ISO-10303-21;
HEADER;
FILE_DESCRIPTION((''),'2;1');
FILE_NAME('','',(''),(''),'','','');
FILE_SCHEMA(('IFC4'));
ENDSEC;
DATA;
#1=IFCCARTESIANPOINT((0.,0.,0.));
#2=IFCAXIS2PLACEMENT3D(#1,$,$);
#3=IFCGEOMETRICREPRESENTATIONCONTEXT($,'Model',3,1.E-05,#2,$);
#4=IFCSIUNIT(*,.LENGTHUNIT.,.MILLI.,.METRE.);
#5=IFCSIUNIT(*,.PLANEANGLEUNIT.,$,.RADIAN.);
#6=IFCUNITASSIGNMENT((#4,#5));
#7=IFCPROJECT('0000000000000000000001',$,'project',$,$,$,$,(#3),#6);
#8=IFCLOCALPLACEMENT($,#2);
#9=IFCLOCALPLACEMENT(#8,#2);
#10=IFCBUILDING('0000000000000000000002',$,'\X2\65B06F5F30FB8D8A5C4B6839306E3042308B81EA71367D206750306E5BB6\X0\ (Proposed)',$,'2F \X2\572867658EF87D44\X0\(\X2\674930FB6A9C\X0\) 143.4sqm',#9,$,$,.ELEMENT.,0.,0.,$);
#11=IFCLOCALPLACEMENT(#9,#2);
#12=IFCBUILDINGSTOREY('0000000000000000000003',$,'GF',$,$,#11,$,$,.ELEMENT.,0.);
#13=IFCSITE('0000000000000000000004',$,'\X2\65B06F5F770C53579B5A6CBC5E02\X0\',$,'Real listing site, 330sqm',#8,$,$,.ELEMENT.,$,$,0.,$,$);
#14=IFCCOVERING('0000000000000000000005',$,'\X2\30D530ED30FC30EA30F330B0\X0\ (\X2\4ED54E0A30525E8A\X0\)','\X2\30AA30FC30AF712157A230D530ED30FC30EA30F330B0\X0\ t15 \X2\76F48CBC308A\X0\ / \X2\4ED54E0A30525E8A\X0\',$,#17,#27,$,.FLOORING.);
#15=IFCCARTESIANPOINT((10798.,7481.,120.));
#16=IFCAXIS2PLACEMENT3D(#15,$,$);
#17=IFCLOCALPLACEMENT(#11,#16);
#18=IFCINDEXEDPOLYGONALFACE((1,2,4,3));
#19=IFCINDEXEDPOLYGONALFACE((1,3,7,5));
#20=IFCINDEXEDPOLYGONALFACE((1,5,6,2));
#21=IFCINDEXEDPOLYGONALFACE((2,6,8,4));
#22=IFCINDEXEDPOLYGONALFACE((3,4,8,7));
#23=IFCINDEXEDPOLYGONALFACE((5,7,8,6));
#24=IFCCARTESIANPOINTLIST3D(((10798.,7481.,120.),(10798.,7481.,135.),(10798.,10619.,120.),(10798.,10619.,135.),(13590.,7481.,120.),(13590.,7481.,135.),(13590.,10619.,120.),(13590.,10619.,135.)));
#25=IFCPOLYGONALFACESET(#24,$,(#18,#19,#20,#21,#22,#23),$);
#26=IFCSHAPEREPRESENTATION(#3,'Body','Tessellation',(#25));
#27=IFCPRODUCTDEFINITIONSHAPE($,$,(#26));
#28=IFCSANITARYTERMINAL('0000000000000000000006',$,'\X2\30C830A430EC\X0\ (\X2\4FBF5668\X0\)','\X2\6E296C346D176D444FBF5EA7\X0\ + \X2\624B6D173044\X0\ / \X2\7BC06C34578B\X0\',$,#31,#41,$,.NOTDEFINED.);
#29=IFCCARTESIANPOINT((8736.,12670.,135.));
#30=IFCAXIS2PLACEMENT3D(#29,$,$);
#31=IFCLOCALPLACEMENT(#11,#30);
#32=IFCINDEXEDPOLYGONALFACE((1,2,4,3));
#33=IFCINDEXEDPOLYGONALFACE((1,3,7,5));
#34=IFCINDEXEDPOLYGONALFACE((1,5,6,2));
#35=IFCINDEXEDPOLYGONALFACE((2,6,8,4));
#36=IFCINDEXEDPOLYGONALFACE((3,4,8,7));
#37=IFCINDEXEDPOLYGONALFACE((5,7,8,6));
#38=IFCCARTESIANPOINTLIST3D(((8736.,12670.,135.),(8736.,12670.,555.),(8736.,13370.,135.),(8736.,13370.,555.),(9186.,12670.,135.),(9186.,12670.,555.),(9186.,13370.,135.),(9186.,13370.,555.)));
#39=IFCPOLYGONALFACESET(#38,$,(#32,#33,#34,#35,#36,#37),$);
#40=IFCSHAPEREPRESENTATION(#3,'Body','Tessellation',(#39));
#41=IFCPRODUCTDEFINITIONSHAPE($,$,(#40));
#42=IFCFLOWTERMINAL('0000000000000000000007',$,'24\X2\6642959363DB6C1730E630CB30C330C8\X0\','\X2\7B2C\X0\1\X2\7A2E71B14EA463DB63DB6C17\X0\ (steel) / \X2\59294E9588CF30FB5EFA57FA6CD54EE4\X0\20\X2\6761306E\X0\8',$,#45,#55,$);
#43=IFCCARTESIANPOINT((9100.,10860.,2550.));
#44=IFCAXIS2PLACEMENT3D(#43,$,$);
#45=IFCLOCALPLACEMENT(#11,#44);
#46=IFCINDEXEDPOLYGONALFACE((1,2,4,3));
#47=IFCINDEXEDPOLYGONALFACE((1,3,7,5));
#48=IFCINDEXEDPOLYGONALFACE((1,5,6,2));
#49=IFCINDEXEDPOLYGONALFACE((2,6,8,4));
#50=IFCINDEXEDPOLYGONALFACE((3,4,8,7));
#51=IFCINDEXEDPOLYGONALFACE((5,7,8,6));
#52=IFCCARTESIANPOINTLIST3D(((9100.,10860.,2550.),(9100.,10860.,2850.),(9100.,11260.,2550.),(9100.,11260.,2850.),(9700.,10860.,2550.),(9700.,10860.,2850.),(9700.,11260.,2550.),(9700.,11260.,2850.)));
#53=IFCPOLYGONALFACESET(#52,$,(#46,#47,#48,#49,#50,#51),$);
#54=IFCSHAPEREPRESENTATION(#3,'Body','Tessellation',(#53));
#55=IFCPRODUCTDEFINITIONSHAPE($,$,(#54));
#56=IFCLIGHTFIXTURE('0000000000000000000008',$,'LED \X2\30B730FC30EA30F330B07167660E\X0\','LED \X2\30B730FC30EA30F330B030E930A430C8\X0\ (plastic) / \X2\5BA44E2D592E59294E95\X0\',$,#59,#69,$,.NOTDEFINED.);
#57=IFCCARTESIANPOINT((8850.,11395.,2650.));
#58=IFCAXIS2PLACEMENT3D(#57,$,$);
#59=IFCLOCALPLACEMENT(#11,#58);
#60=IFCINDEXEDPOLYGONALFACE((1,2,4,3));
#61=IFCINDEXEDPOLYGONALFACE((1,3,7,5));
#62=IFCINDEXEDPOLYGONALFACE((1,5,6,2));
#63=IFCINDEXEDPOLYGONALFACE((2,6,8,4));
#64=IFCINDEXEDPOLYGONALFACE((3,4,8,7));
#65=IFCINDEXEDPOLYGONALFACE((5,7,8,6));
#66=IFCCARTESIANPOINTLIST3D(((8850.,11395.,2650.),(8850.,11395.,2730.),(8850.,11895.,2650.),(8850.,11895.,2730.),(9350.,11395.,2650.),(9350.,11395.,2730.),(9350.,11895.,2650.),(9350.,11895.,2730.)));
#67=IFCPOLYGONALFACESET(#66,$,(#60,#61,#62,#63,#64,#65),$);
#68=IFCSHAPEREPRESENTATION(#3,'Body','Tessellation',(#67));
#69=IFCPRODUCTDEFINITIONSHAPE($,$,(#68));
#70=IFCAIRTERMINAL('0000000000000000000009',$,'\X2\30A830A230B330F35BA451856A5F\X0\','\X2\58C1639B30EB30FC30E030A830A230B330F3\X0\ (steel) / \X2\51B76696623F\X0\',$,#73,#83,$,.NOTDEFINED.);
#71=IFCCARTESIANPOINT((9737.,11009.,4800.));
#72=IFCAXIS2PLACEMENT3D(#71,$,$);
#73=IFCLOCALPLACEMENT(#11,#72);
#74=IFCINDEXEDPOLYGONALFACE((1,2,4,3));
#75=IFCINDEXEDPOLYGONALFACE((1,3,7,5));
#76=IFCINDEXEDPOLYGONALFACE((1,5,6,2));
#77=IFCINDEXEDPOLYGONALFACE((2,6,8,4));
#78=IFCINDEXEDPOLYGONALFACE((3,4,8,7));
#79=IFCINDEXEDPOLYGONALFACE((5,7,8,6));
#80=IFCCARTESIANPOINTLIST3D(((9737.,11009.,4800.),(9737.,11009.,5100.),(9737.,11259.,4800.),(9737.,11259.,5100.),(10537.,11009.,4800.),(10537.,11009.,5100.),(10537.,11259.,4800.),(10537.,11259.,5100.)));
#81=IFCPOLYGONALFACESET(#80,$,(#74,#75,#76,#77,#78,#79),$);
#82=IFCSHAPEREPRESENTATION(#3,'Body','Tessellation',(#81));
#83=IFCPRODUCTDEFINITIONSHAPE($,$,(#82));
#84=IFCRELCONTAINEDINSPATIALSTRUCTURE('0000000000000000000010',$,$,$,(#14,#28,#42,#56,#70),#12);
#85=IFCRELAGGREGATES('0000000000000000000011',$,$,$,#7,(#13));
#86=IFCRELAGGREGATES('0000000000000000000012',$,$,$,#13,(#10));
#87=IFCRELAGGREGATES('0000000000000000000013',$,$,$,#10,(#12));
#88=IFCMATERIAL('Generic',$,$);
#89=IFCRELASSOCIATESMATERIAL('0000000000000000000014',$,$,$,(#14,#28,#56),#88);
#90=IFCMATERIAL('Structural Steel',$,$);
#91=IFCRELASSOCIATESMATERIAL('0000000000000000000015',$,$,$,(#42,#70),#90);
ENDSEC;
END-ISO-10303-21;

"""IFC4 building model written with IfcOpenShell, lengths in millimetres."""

from ifc_helpers import new_model, si_unit, frame, frame_2d, origin, place, context, project, spatial, rectangle, extrude, material, element, save


model = new_model("IFC4")

# Units and contexts
model_context = context("Model", 3, precision=1e-05, world=origin())
ifc_project = project(units=[si_unit("LENGTHUNIT", "METRE", prefix="MILLI"), si_unit("PLANEANGLEUNIT", "RADIAN")], contexts=[model_context])

# Site, building, storey
site_placement = place(None, origin())
site = spatial("IfcSite", under=ifc_project, at=site_placement, Name="新潟県南魚沼市", ObjectType="Real listing site, 330sqm", CompositionType="ELEMENT", RefElevation=0.0)
building_placement = place(site_placement, origin())
building = spatial("IfcBuilding", under=site, at=building_placement, Name="新潟・越屋根のある自然素材の家 (Proposed)", ObjectType="2F 在来軸組(杉・檜) 143.4sqm", CompositionType="ELEMENT", ElevationOfRefHeight=0.0, ElevationOfTerrain=0.0)
storey_placement = place(building_placement, origin())
storey = spatial("IfcBuildingStorey", under=building, at=storey_placement, Name="GF", CompositionType="ELEMENT", Elevation=0.0)

# Covering
ifc_material_1 = material(Name="Generic")
covering_placement = place(storey_placement, frame((10798.0, 7481.0, 120.0)))
element("IfcCovering", 1, at=covering_placement, inside=storey, material=ifc_material_1, Name="フローリング (仕上げ床)", Description="オーク無垢フローリング t15 直貼り / 仕上げ床", PredefinedType="FLOORING", context=model_context, shape_type="SweptSolid", body=[
    extrude(rectangle(XDim=2792.0, YDim=3138.0, at=frame_2d((1396.0, 1569.0))), frame((10798.0, 7481.0, 120.0)), (0.0, 0.0, 1.0), 15.0),
])

# Sanitary terminal
sanitary_terminal_placement = place(storey_placement, frame((8736.0, 12670.0, 135.0)))
element("IfcSanitaryTerminal", 2, at=sanitary_terminal_placement, inside=storey, material=ifc_material_1, Name="トイレ (便器)", Description="温水洗浄便座 + 手洗い / 節水型", PredefinedType="NOTDEFINED", context=model_context, shape_type="SweptSolid", body=[
    extrude(rectangle(XDim=450.0, YDim=700.0, at=frame_2d((225.0, 350.0))), frame((8736.0, 12670.0, 135.0)), (0.0, 0.0, 1.0), 420.0),
])

# Flow terminal
ifc_material_2 = material(Name="Structural Steel")
flow_terminal_placement = place(storey_placement, frame((9100.0, 10860.0, 2550.0)))
element("IfcFlowTerminal", 3, at=flow_terminal_placement, inside=storey, material=ifc_material_2, Name="24時間換気ユニット", Description="第1種熱交換換気 (steel) / 天井裏・建基法令20条の8", context=model_context, shape_type="SweptSolid", body=[
    extrude(rectangle(XDim=600.0, YDim=400.0, at=frame_2d((300.0, 200.0))), frame((9100.0, 10860.0, 2550.0)), (0.0, 0.0, 1.0), 300.0),
])

# Light fixture
light_fixture_placement = place(storey_placement, frame((8850.0, 11395.0, 2650.0)))
element("IfcLightFixture", 4, at=light_fixture_placement, inside=storey, material=ifc_material_1, Name="LED シーリング照明", Description="LED シーリングライト (plastic) / 室中央天井", PredefinedType="NOTDEFINED", context=model_context, shape_type="SweptSolid", body=[
    extrude(rectangle(XDim=500.0, YDim=500.0, at=frame_2d((250.0, 250.0))), frame((8850.0, 11395.0, 2650.0)), (0.0, 0.0, 1.0), 80.0),
])

# Air terminal
air_terminal_placement = place(storey_placement, frame((9737.0, 11009.0, 4800.0)))
element("IfcAirTerminal", 5, at=air_terminal_placement, inside=storey, material=ifc_material_2, Name="エアコン室内機", Description="壁掛ルームエアコン (steel) / 冷暖房", PredefinedType="NOTDEFINED", context=model_context, shape_type="SweptSolid", body=[
    extrude(rectangle(XDim=800.0, YDim=250.0, at=frame_2d((400.0, 125.0))), frame((9737.0, 11009.0, 4800.0)), (0.0, 0.0, 1.0), 300.0),
])

save(model, "model.ifc")
